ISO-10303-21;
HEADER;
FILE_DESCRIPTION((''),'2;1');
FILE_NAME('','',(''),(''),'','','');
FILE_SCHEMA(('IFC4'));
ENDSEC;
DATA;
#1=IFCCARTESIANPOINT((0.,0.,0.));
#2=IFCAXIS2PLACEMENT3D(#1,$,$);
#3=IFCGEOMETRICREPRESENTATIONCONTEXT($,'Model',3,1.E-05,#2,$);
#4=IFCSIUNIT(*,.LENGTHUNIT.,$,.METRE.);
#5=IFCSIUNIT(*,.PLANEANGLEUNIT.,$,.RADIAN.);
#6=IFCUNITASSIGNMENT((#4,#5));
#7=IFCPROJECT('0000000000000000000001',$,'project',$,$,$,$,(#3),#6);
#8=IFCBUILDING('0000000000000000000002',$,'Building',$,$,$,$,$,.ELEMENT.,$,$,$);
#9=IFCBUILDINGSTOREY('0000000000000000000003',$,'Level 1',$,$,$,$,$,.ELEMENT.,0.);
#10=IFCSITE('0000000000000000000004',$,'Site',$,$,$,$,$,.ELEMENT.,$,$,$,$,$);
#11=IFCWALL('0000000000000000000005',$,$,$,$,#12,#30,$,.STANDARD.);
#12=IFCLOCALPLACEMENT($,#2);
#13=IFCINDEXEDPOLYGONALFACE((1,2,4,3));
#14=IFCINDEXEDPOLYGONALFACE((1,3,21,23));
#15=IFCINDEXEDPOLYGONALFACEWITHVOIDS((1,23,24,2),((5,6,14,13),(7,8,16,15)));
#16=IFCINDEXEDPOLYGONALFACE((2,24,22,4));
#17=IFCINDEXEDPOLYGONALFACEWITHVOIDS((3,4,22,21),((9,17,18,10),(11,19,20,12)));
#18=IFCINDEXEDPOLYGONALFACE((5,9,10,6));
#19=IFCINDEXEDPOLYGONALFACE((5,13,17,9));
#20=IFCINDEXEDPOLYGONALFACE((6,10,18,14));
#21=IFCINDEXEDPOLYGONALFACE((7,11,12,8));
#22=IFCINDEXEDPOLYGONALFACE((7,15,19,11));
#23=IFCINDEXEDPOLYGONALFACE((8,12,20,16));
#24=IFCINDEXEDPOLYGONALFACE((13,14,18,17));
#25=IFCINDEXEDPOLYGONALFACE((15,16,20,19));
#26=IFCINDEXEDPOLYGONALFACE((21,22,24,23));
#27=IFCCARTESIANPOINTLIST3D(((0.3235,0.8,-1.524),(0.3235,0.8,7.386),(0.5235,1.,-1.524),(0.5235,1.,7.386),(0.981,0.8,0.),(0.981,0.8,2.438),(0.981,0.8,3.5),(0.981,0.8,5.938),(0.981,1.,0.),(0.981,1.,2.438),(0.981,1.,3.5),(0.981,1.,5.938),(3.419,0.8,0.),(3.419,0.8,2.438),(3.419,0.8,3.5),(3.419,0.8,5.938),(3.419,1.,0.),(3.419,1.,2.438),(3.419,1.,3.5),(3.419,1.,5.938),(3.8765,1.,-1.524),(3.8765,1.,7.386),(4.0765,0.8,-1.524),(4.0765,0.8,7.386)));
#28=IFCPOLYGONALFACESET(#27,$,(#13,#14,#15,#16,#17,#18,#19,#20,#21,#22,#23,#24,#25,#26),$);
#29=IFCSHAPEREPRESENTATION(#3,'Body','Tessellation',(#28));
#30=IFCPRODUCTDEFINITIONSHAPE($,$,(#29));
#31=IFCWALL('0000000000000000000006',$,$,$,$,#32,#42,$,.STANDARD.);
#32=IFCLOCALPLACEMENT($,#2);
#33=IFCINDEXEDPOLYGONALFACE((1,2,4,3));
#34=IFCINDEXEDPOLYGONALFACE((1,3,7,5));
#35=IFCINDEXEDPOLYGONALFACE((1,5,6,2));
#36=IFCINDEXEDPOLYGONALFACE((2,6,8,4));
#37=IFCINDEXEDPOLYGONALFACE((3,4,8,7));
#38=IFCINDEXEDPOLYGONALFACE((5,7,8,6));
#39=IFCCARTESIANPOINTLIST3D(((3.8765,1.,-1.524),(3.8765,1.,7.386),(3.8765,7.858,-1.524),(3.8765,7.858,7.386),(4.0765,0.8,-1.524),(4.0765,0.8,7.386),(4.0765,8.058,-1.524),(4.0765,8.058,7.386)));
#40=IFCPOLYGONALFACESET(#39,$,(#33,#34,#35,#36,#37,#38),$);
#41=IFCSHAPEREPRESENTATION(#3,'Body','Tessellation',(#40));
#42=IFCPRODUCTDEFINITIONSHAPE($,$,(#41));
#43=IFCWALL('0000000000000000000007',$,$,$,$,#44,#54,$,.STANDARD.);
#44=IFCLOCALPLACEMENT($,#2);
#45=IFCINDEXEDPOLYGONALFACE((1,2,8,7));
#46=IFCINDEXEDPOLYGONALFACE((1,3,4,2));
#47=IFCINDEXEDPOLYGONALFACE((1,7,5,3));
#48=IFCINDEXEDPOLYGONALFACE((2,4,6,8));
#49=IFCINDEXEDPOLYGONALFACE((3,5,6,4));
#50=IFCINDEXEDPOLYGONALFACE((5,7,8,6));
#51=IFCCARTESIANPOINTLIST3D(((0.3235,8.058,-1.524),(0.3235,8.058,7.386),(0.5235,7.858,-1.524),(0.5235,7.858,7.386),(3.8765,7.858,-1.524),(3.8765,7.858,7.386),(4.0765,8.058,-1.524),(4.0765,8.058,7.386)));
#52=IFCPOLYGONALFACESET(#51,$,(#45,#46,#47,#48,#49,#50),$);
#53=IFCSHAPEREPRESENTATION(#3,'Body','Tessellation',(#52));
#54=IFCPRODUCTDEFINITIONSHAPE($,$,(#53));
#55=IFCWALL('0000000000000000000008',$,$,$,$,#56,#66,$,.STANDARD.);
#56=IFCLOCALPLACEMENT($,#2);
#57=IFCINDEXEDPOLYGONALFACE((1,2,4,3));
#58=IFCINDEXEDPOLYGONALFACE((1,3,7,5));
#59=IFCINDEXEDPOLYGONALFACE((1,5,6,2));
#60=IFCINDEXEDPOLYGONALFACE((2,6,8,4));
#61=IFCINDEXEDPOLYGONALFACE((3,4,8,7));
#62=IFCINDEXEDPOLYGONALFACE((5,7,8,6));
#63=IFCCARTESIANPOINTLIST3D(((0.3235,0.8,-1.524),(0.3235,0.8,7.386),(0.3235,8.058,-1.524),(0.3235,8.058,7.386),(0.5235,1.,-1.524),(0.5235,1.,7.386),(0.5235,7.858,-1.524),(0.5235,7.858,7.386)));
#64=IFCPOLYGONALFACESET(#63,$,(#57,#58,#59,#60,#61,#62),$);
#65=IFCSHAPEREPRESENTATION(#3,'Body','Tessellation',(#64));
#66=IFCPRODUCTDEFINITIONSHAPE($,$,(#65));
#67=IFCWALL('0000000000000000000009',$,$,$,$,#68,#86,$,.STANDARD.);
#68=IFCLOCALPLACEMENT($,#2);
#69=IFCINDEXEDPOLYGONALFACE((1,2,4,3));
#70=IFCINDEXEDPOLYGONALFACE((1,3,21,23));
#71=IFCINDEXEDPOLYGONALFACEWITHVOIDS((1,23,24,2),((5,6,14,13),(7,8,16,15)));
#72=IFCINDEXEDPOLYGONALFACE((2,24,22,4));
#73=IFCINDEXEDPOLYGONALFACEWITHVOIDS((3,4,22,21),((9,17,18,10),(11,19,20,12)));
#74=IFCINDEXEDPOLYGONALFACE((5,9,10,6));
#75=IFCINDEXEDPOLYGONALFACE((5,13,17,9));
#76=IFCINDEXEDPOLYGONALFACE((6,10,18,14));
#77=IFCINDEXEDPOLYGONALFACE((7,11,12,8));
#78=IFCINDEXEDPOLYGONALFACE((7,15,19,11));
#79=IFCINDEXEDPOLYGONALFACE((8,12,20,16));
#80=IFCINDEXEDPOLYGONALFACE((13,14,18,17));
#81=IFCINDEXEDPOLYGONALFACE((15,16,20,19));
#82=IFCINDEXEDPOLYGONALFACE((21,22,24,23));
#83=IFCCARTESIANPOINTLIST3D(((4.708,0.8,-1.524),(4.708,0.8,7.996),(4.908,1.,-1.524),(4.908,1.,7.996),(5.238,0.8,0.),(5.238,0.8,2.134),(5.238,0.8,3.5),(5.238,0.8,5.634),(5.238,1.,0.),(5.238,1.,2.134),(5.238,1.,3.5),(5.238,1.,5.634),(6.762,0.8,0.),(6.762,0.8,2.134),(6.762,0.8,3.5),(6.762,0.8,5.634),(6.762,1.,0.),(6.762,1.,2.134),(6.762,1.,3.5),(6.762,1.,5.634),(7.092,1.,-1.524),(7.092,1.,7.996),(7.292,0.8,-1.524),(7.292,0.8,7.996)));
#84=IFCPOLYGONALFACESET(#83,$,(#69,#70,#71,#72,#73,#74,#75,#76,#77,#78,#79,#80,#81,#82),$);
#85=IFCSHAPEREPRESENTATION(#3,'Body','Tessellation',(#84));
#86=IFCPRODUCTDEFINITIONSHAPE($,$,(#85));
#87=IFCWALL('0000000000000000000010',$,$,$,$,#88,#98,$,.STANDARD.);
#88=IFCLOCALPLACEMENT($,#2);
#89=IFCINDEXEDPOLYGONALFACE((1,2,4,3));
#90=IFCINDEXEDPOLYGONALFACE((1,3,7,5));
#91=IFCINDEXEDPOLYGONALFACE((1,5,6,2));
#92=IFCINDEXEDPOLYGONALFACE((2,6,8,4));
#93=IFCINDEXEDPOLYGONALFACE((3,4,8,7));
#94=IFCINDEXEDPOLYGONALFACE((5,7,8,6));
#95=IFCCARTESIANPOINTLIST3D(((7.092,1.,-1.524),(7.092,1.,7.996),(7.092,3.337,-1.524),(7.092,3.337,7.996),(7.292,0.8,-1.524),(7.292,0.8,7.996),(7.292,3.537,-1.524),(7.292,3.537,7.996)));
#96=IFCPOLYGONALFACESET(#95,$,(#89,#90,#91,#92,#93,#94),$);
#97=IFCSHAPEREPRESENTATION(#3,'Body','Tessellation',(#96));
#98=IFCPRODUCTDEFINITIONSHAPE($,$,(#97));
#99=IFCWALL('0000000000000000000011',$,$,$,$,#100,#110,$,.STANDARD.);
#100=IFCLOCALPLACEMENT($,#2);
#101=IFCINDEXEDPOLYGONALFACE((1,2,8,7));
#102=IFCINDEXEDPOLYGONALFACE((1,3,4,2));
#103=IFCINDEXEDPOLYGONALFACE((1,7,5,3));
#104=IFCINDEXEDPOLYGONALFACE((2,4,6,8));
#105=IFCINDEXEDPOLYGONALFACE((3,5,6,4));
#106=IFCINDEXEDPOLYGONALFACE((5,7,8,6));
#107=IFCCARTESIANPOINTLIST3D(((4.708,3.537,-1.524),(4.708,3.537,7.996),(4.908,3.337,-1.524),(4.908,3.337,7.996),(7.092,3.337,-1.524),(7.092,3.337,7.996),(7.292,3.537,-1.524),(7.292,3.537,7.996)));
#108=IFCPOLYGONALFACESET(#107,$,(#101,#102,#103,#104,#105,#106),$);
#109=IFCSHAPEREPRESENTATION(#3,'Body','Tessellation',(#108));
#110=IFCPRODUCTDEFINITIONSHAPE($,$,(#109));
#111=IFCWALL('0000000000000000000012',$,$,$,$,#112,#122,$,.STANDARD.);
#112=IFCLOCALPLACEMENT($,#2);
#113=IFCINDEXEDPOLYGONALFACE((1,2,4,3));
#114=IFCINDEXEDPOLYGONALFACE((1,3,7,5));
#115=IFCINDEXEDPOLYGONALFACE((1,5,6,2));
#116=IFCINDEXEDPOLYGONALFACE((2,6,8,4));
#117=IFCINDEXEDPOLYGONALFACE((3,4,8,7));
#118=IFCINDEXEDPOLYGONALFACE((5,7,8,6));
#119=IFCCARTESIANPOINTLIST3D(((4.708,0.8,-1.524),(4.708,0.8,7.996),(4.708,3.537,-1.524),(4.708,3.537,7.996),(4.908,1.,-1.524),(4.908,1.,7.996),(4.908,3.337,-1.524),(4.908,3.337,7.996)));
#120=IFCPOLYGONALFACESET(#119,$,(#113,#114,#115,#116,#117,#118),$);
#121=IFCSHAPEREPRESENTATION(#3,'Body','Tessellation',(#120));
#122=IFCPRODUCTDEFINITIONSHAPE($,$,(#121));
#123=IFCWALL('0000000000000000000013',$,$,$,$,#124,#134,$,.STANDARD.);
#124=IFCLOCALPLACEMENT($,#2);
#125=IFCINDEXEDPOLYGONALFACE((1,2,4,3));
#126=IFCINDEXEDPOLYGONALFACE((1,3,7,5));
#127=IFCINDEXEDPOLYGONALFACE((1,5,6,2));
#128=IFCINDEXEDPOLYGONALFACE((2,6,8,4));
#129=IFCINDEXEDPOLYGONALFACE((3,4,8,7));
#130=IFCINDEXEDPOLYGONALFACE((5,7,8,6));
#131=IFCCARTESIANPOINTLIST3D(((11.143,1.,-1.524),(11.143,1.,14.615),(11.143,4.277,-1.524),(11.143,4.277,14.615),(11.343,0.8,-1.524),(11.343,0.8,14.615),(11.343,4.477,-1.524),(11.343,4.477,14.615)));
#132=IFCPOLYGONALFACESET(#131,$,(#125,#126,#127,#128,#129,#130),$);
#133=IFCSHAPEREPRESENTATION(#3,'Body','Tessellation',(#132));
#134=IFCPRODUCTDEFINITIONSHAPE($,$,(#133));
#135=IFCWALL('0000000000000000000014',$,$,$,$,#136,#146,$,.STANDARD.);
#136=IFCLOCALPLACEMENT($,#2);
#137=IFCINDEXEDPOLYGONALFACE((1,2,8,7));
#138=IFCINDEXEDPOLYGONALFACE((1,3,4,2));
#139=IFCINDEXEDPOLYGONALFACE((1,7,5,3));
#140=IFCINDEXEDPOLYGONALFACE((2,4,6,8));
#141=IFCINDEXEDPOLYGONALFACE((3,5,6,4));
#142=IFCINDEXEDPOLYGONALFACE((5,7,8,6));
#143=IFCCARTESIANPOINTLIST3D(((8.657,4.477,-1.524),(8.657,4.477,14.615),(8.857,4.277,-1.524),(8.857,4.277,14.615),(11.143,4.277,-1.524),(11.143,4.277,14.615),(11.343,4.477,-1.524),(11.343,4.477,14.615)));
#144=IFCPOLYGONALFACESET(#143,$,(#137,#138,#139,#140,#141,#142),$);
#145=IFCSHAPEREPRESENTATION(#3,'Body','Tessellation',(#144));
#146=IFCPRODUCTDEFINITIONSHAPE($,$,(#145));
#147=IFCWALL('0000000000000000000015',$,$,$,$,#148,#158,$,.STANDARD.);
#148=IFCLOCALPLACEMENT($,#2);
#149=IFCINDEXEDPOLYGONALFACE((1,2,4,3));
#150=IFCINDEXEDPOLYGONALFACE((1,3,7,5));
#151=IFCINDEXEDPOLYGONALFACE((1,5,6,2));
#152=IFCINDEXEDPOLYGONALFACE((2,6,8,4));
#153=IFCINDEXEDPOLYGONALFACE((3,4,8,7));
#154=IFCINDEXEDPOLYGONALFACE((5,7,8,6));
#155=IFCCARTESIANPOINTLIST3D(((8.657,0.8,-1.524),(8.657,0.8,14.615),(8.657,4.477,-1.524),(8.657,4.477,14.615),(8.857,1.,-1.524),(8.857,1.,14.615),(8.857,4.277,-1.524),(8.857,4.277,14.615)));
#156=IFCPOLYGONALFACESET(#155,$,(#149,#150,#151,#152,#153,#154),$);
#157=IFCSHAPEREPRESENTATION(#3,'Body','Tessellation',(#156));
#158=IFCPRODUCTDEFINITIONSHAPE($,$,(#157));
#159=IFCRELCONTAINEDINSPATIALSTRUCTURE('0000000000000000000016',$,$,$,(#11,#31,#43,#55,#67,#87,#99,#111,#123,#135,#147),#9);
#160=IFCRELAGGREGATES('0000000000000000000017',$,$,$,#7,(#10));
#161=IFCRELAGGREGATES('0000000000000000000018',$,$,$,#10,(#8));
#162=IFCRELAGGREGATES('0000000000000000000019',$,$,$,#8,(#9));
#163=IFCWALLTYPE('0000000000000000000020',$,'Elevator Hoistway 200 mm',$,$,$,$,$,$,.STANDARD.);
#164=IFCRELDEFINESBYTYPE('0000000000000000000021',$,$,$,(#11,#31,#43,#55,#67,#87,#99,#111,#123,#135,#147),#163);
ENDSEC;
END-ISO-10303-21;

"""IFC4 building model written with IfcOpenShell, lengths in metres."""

from ifc_helpers import new_model, si_unit, frame, origin, origin_2d, place, context, project, spatial, polyline, rectangle, outline, extrude, type_object, element, save


model = new_model("IFC4")

# Units and contexts
model_context = context("Model", 3, precision=1e-05, world=origin())
ifc_project = project(units=[si_unit("LENGTHUNIT", "METRE"), si_unit("PLANEANGLEUNIT", "RADIAN")], contexts=[model_context])

# Site, building, storey
site = spatial("IfcSite", under=ifc_project, Name="Site", CompositionType="ELEMENT")
building = spatial("IfcBuilding", under=site, Name="Building", CompositionType="ELEMENT")
storey = spatial("IfcBuildingStorey", under=building, Name="Level 1", CompositionType="ELEMENT", Elevation=0.0)

# Wall, openings
wall_type = type_object("IfcWallType", Name="Elevator Hoistway 200 mm", PredefinedType="STANDARD")
wall_1_placement = place(None, frame((0.4235, 0.9, -1.524), z_axis=(0.0, 0.0, 1.0), x_axis=(1.0, 0.0, 0.0)))
wall_1 = element("IfcWall", 1, at=wall_1_placement, inside=storey, type_object=wall_type, PredefinedType="STANDARD", context=model_context, shape_type="SweptSolid", body=[
    extrude(outline(polyline([(-0.1, -0.1), (3.653, -0.1), (3.453, 0.1), (0.1, 0.1), (-0.1, -0.1)])), origin(), (0.0, 0.0, 1.0), 8.91),
])
opening_1_placement = place(wall_1_placement, frame((1.7765, 0.0, 1.524), z_axis=(0.0, 0.0, 1.0), x_axis=(1.0, 0.0, 0.0)))
element("IfcOpeningElement", 2, at=opening_1_placement, cuts=wall_1, PredefinedType="OPENING", context=model_context, shape_type="SweptSolid", body=[
    extrude(rectangle(XDim=2.438, YDim=0.202, at=origin_2d()), origin(), (0.0, 0.0, 1.0), 2.438),
])
opening_2_placement = place(wall_1_placement, frame((1.7765, 0.0, 5.024), z_axis=(0.0, 0.0, 1.0), x_axis=(1.0, 0.0, 0.0)))
element("IfcOpeningElement", 3, at=opening_2_placement, cuts=wall_1, PredefinedType="OPENING", context=model_context, shape_type="SweptSolid", body=[
    extrude(rectangle(XDim=2.438, YDim=0.202, at=origin_2d()), origin(), (0.0, 0.0, 1.0), 2.438),
])

# Walls
wall_2_placement = place(None, frame((3.9765, 0.9, -1.524), z_axis=(0.0, 0.0, 1.0), x_axis=(0.0, 1.0, 0.0)))
element("IfcWall", 4, at=wall_2_placement, inside=storey, type_object=wall_type, PredefinedType="STANDARD", context=model_context, shape_type="SweptSolid", body=[
    extrude(outline(polyline([(-0.1, -0.1), (7.158, -0.1), (6.958, 0.1), (0.1, 0.1), (-0.1, -0.1)])), origin(), (0.0, 0.0, 1.0), 8.91),
])
wall_3_placement = place(None, frame((3.9765, 7.958, -1.524), z_axis=(0.0, 0.0, 1.0), x_axis=(-1.0, 0.0, 0.0)))
element("IfcWall", 5, at=wall_3_placement, inside=storey, type_object=wall_type, PredefinedType="STANDARD", context=model_context, shape_type="SweptSolid", body=[
    extrude(outline(polyline([(-0.1, -0.1), (3.653, -0.1), (3.453, 0.1), (0.1, 0.1), (-0.1, -0.1)])), origin(), (0.0, 0.0, 1.0), 8.91),
])
wall_4_placement = place(None, frame((0.4235, 7.958, -1.524), z_axis=(0.0, 0.0, 1.0), x_axis=(0.0, -1.0, 0.0)))
element("IfcWall", 6, at=wall_4_placement, inside=storey, type_object=wall_type, PredefinedType="STANDARD", context=model_context, shape_type="SweptSolid", body=[
    extrude(outline(polyline([(-0.1, -0.1), (7.158, -0.1), (6.958, 0.1), (0.1, 0.1), (-0.1, -0.1)])), origin(), (0.0, 0.0, 1.0), 8.91),
])

# Wall, openings
wall_5_placement = place(None, frame((4.808, 0.9, -1.524), z_axis=(0.0, 0.0, 1.0), x_axis=(1.0, 0.0, 0.0)))
wall_5 = element("IfcWall", 7, at=wall_5_placement, inside=storey, type_object=wall_type, PredefinedType="STANDARD", context=model_context, shape_type="SweptSolid", body=[
    extrude(outline(polyline([(-0.1, -0.1), (2.484, -0.1), (2.284, 0.1), (0.1, 0.1), (-0.1, -0.1)])), origin(), (0.0, 0.0, 1.0), 9.52),
])
opening_3_placement = place(wall_5_placement, frame((1.192, 0.0, 1.524), z_axis=(0.0, 0.0, 1.0), x_axis=(1.0, 0.0, 0.0)))
element("IfcOpeningElement", 8, at=opening_3_placement, cuts=wall_5, PredefinedType="OPENING", context=model_context, shape_type="SweptSolid", body=[
    extrude(rectangle(XDim=1.524, YDim=0.202, at=origin_2d()), origin(), (0.0, 0.0, 1.0), 2.134),
])
opening_4_placement = place(wall_5_placement, frame((1.192, 0.0, 5.024), z_axis=(0.0, 0.0, 1.0), x_axis=(1.0, 0.0, 0.0)))
element("IfcOpeningElement", 9, at=opening_4_placement, cuts=wall_5, PredefinedType="OPENING", context=model_context, shape_type="SweptSolid", body=[
    extrude(rectangle(XDim=1.524, YDim=0.202, at=origin_2d()), origin(), (0.0, 0.0, 1.0), 2.134),
])

# Walls
wall_6_placement = place(None, frame((7.192, 0.9, -1.524), z_axis=(0.0, 0.0, 1.0), x_axis=(0.0, 1.0, 0.0)))
element("IfcWall", 10, at=wall_6_placement, inside=storey, type_object=wall_type, PredefinedType="STANDARD", context=model_context, shape_type="SweptSolid", body=[
    extrude(outline(polyline([(-0.1, -0.1), (2.637, -0.1), (2.437, 0.1), (0.1, 0.1), (-0.1, -0.1)])), origin(), (0.0, 0.0, 1.0), 9.52),
])
wall_7_placement = place(None, frame((7.192, 3.437, -1.524), z_axis=(0.0, 0.0, 1.0), x_axis=(-1.0, 0.0, 0.0)))
element("IfcWall", 11, at=wall_7_placement, inside=storey, type_object=wall_type, PredefinedType="STANDARD", context=model_context, shape_type="SweptSolid", body=[
    extrude(outline(polyline([(-0.1, -0.1), (2.484, -0.1), (2.284, 0.1), (0.1, 0.1), (-0.1, -0.1)])), origin(), (0.0, 0.0, 1.0), 9.52),
])
wall_8_placement = place(None, frame((4.808, 3.437, -1.524), z_axis=(0.0, 0.0, 1.0), x_axis=(0.0, -1.0, 0.0)))
element("IfcWall", 12, at=wall_8_placement, inside=storey, type_object=wall_type, PredefinedType="STANDARD", context=model_context, shape_type="SweptSolid", body=[
    extrude(outline(polyline([(-0.1, -0.1), (2.637, -0.1), (2.437, 0.1), (0.1, 0.1), (-0.1, -0.1)])), origin(), (0.0, 0.0, 1.0), 9.52),
])

# Walls
wall_9_placement = place(None, frame((11.243, 0.9, -1.524), z_axis=(0.0, 0.0, 1.0), x_axis=(0.0, 1.0, 0.0)))
element("IfcWall", 13, at=wall_9_placement, inside=storey, type_object=wall_type, PredefinedType="STANDARD", context=model_context, shape_type="SweptSolid", body=[
    extrude(outline(polyline([(-0.1, -0.1), (3.577, -0.1), (3.377, 0.1), (0.1, 0.1), (-0.1, -0.1)])), origin(), (0.0, 0.0, 1.0), 16.139),
])
wall_10_placement = place(None, frame((11.243, 4.377, -1.524), z_axis=(0.0, 0.0, 1.0), x_axis=(-1.0, 0.0, 0.0)))
element("IfcWall", 14, at=wall_10_placement, inside=storey, type_object=wall_type, PredefinedType="STANDARD", context=model_context, shape_type="SweptSolid", body=[
    extrude(outline(polyline([(-0.1, -0.1), (2.586, -0.1), (2.386, 0.1), (0.1, 0.1), (-0.1, -0.1)])), origin(), (0.0, 0.0, 1.0), 16.139),
])
wall_11_placement = place(None, frame((8.757, 4.377, -1.524), z_axis=(0.0, 0.0, 1.0), x_axis=(0.0, -1.0, 0.0)))
element("IfcWall", 15, at=wall_11_placement, inside=storey, type_object=wall_type, PredefinedType="STANDARD", context=model_context, shape_type="SweptSolid", body=[
    extrude(outline(polyline([(-0.1, -0.1), (3.577, -0.1), (3.377, 0.1), (0.1, 0.1), (-0.1, -0.1)])), origin(), (0.0, 0.0, 1.0), 16.139),
])

save(model, "model.ifc")
